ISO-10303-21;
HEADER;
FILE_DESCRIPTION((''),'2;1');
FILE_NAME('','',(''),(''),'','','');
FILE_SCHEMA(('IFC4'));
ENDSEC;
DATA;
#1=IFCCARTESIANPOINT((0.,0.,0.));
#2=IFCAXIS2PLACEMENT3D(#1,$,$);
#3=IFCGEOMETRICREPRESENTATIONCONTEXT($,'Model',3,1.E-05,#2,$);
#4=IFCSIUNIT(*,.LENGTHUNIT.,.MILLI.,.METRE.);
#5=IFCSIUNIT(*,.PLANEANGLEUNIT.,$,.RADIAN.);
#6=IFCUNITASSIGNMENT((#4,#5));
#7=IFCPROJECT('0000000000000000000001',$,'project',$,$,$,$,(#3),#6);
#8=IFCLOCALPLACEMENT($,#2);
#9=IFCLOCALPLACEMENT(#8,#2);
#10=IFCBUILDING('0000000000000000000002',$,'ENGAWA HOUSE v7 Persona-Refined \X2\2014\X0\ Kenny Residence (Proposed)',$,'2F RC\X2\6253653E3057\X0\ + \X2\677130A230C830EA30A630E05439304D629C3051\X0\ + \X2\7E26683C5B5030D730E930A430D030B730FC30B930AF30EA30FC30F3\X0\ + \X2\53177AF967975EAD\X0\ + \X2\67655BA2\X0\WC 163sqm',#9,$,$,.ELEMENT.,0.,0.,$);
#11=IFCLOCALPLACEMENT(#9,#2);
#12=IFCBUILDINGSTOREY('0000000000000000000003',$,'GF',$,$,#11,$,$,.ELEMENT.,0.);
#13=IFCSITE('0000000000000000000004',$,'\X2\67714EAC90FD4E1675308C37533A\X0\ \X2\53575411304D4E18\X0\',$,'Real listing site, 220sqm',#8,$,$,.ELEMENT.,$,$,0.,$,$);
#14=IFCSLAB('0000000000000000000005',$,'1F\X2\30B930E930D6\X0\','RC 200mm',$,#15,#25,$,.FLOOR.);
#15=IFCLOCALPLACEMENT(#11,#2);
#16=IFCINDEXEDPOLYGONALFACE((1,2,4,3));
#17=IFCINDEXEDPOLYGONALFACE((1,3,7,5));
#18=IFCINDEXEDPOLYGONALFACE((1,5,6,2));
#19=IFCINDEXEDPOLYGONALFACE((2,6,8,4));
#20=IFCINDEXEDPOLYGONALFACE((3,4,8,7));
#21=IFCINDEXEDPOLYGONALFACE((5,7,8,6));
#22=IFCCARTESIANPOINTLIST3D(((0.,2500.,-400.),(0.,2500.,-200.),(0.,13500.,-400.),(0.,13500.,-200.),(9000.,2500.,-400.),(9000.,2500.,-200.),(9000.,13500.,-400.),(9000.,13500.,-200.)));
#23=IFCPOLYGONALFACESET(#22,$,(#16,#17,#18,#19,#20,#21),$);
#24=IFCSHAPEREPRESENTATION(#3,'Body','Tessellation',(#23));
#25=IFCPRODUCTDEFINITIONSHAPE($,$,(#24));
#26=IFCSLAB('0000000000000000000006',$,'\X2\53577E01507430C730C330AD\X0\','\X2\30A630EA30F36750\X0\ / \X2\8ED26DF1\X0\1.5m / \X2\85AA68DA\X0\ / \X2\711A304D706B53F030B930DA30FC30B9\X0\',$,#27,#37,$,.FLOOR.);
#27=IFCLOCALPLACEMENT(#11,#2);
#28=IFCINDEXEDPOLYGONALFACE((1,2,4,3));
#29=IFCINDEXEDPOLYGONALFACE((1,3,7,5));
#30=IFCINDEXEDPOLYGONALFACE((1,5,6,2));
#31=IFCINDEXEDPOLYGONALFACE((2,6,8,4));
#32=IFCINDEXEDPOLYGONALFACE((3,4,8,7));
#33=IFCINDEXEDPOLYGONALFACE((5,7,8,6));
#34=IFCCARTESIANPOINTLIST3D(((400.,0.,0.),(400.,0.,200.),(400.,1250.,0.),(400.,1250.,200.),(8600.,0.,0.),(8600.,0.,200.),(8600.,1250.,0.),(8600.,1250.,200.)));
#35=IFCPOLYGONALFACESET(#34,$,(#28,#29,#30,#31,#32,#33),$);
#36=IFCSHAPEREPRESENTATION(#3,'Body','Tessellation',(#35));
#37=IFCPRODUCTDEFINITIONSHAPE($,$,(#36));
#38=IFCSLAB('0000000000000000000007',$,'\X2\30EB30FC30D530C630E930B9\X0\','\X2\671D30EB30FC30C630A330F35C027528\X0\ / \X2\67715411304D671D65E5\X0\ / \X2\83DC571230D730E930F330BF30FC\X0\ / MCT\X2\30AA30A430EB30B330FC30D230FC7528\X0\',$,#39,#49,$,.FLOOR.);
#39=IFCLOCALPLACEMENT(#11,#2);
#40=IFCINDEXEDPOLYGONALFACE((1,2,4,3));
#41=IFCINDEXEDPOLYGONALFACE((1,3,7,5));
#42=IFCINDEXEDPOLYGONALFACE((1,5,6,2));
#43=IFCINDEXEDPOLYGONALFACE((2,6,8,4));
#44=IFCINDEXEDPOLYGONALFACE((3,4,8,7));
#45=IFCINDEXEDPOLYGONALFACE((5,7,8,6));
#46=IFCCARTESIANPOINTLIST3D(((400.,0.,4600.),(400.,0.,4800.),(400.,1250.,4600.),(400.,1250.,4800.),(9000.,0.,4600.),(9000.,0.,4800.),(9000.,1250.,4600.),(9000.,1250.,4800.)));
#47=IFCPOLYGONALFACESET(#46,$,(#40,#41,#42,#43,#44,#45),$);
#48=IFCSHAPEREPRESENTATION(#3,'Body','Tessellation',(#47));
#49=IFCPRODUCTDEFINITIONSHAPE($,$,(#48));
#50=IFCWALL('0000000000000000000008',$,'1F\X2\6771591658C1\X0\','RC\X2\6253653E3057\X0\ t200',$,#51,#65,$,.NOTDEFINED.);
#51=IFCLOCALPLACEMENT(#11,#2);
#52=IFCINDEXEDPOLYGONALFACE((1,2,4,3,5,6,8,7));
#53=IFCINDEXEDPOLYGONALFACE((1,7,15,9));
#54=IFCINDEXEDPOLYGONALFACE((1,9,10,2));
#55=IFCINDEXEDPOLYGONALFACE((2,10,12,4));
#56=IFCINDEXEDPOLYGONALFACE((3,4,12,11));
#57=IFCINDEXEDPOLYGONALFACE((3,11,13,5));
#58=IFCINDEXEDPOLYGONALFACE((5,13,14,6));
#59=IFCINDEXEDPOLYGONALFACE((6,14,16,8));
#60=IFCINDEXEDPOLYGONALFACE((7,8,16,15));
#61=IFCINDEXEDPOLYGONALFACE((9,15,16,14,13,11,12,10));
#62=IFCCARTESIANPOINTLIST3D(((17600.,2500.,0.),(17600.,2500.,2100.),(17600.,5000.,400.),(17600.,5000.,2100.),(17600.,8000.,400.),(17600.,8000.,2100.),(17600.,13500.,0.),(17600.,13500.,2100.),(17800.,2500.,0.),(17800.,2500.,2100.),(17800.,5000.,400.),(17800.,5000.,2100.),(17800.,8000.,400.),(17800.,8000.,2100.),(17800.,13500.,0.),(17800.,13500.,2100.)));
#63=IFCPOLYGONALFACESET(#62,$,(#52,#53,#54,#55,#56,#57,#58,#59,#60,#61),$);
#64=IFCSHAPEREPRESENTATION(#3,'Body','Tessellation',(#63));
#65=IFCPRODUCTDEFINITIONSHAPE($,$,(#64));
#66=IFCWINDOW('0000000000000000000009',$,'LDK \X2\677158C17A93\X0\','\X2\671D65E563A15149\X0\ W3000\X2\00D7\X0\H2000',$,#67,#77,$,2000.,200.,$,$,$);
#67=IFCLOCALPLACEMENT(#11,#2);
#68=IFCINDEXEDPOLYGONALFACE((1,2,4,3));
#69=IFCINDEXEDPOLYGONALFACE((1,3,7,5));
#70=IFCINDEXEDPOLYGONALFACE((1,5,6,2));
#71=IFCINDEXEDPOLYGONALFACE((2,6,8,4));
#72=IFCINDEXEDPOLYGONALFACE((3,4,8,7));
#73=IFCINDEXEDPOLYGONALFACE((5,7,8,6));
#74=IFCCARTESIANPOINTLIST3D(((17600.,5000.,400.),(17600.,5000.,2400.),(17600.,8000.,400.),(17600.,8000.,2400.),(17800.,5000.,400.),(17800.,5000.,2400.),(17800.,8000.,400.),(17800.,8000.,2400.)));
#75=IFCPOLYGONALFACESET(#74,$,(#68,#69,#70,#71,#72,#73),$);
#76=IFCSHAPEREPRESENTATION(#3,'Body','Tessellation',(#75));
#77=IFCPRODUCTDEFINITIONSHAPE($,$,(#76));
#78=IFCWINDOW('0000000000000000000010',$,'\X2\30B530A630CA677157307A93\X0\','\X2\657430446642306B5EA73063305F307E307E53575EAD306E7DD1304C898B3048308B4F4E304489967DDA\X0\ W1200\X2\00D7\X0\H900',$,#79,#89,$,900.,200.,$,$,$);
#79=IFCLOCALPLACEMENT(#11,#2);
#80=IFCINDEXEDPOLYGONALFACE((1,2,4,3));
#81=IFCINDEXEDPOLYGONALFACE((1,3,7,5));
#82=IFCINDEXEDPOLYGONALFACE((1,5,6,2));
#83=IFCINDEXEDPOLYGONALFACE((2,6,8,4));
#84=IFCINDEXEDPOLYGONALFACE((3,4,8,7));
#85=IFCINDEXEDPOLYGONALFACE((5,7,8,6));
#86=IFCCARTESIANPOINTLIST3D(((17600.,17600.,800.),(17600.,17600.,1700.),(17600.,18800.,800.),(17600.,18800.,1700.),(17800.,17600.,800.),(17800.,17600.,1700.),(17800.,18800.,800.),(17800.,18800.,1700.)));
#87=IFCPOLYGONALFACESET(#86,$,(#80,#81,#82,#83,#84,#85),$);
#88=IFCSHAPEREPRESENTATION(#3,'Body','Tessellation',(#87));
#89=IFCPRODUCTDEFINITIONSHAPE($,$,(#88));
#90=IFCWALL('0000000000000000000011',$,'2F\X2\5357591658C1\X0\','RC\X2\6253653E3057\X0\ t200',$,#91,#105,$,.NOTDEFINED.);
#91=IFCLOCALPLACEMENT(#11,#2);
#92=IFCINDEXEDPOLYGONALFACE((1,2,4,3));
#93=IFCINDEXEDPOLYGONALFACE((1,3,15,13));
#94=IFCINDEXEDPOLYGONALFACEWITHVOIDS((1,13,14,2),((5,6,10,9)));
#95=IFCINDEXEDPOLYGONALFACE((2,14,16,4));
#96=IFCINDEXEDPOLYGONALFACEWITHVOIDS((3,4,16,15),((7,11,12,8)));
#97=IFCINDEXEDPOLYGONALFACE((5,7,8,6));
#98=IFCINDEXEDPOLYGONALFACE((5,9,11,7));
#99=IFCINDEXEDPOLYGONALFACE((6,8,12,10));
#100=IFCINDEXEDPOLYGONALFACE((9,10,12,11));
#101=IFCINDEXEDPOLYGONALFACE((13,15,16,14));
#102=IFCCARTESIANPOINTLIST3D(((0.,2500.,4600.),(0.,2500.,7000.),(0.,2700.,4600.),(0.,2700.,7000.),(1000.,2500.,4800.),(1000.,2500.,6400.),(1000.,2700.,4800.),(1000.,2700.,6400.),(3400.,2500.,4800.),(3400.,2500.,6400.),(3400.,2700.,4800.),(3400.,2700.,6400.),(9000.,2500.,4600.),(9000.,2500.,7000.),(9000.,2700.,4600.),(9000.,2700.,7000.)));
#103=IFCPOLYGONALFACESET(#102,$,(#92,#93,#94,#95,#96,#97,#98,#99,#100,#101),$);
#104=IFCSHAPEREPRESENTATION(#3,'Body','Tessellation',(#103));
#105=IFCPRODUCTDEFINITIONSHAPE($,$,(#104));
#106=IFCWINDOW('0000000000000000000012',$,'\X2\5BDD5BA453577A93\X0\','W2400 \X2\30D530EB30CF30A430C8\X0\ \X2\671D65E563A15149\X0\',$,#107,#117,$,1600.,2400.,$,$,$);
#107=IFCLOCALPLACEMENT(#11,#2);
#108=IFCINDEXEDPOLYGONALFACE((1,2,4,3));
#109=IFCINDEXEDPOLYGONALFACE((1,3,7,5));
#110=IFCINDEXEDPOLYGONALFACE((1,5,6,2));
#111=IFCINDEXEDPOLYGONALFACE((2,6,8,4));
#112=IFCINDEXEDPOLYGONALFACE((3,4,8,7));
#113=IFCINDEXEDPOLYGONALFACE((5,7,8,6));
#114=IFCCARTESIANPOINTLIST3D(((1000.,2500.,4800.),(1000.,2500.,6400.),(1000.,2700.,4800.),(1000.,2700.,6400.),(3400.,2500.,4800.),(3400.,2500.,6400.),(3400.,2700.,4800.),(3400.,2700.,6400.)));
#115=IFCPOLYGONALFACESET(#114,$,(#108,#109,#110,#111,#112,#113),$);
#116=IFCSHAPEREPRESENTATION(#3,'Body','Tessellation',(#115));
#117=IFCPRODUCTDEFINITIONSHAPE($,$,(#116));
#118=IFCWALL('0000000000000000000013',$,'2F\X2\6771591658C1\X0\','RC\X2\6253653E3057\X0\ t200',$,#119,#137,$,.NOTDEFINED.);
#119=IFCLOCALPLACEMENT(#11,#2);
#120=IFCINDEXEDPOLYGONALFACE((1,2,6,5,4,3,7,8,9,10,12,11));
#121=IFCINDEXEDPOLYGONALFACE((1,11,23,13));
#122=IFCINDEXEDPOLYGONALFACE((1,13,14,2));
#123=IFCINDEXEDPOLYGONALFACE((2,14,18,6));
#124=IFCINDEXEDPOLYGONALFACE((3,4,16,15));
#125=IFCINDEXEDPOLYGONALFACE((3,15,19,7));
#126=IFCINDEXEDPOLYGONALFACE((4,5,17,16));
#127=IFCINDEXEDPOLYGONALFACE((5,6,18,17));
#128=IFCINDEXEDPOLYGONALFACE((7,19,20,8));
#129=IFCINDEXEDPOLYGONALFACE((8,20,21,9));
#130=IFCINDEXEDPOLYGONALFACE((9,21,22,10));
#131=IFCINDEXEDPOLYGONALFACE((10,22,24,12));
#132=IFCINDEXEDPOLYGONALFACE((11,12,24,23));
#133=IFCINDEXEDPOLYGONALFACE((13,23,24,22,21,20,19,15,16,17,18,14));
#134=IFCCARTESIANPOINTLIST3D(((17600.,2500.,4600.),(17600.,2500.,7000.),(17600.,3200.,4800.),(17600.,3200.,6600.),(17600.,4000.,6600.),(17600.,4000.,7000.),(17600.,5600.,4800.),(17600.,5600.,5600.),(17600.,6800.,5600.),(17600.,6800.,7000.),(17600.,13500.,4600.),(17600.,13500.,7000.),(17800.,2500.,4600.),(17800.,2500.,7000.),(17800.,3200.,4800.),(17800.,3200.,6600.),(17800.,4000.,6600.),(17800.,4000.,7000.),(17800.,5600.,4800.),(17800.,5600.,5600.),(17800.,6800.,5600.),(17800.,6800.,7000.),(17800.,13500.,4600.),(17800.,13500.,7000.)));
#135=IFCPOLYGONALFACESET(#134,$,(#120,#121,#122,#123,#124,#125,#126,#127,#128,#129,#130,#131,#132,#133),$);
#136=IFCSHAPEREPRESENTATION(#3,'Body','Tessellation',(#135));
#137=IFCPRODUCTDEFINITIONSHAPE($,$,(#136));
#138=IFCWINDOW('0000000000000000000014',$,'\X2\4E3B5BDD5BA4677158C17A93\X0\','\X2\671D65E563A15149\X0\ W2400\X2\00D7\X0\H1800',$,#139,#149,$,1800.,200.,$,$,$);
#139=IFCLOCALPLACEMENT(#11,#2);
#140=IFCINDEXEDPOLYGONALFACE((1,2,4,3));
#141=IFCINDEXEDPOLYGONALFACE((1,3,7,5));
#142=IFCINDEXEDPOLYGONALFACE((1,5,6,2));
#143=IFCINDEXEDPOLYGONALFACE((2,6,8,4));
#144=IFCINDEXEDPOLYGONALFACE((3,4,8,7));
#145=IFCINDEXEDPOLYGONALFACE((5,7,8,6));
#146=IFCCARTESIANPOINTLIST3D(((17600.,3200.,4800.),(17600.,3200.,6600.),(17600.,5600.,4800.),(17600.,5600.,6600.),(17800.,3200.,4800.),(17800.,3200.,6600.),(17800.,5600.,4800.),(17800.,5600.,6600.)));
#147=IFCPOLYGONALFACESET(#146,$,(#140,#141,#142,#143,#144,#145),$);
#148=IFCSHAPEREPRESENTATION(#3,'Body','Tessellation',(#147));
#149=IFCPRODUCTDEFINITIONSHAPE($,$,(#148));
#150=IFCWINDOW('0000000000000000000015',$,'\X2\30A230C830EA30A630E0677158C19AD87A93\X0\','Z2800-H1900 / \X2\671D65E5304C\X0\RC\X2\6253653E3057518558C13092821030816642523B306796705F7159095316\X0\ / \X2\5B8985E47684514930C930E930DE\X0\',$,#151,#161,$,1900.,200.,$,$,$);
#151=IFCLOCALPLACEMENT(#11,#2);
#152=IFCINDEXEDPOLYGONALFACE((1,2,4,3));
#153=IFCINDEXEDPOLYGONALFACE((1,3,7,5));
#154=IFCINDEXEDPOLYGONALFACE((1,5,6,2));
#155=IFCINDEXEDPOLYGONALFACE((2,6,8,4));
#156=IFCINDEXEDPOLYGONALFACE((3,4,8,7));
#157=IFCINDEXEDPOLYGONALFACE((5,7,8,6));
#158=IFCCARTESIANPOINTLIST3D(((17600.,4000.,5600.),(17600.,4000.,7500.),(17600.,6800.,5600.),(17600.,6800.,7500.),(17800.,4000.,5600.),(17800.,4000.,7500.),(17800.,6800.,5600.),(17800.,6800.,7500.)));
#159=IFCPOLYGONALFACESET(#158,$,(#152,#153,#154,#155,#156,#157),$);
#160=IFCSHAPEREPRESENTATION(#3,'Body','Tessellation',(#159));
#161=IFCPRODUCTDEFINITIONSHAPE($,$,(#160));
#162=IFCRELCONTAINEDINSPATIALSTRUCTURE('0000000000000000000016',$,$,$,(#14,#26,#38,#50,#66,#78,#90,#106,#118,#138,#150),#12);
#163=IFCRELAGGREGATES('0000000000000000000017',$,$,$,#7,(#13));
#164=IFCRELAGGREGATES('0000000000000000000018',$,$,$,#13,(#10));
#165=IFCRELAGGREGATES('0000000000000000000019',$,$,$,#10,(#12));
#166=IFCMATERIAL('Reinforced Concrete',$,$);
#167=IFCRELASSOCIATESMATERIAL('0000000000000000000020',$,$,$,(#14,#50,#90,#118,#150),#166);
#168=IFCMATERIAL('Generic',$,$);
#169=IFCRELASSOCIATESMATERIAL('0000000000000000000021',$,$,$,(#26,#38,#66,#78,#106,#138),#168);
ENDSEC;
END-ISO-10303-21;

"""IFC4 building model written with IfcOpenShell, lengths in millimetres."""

from ifc_helpers import new_model, si_unit, frame, frame_2d, origin, place, context, project, spatial, rectangle, extrude, material, element, fill, save


model = new_model("IFC4")

# Units and contexts
model_context = context("Model", 3, precision=1e-05, world=origin())
ifc_project = project(units=[si_unit("LENGTHUNIT", "METRE", prefix="MILLI"), si_unit("PLANEANGLEUNIT", "RADIAN")], contexts=[model_context])

# Site, building, storey
site_placement = place(None, origin())
site = spatial("IfcSite", under=ifc_project, at=site_placement, Name="東京都世田谷区 南向き丘", ObjectType="Real listing site, 220sqm", CompositionType="ELEMENT", RefElevation=0.0)
building_placement = place(site_placement, origin())
building = spatial("IfcBuilding", under=site, at=building_placement, Name="ENGAWA HOUSE v7 Persona-Refined — Kenny Residence (Proposed)", ObjectType="2F RC打放し + 東アトリウム吹き抜け + 縦格子プライバシースクリーン + 北竹林庭 + 来客WC 163sqm", CompositionType="ELEMENT", ElevationOfRefHeight=0.0, ElevationOfTerrain=0.0)
storey_placement = place(building_placement, origin())
storey = spatial("IfcBuildingStorey", under=building, at=storey_placement, Name="GF", CompositionType="ELEMENT", Elevation=0.0)

# Shared definitions
ifc_material_1 = material(Name="Generic")

# Slabs
ifc_material_2 = material(Name="Reinforced Concrete")
slab_1_placement = place(storey_placement, frame((0.0, 1250.0, -200.0)))
element("IfcSlab", 1, at=slab_1_placement, inside=storey, material=ifc_material_2, Name="1Fスラブ", Description="RC 200mm", PredefinedType="FLOOR", context=model_context, shape_type="SweptSolid", body=[
    extrude(rectangle(XDim=9000.0, YDim=11000.0, at=frame_2d((4500.0, 5500.0))), frame((0.0, 1250.0, -200.0)), (0.0, 0.0, 1.0), 200.0),
])
slab_2_placement = place(storey_placement, frame((200.0, 0.0, 0.0)))
element("IfcSlab", 2, at=slab_2_placement, inside=storey, material=ifc_material_1, Name="南縁側デッキ", Description="ウリン材 / 軒深1.5m / 薪棚 / 焚き火台スペース", PredefinedType="FLOOR", context=model_context, shape_type="SweptSolid", body=[
    extrude(rectangle(XDim=8200.0, YDim=1250.0, at=frame_2d((4100.0, 625.0))), frame((200.0, 0.0, 0.0)), (0.0, 0.0, 1.0), 200.0),
])
slab_3_placement = place(storey_placement, frame((200.0, 0.0, 2300.0)))
element("IfcSlab", 3, at=slab_3_placement, inside=storey, material=ifc_material_1, Name="ルーフテラス", Description="朝ルーティン専用 / 東向き朝日 / 菜園プランター / MCTオイルコーヒー用", PredefinedType="FLOOR", context=model_context, shape_type="SweptSolid", body=[
    extrude(rectangle(XDim=8600.0, YDim=1250.0, at=frame_2d((4300.0, 625.0))), frame((200.0, 0.0, 2300.0)), (0.0, 0.0, 1.0), 200.0),
])

# Wall, openings, windows
wall_1_placement = place(storey_placement, frame((8800.0, 1250.0, 0.0)))
wall_1 = element("IfcWall", 4, at=wall_1_placement, inside=storey, material=ifc_material_2, Name="1F東外壁", Description="RC打放し t200", PredefinedType="NOTDEFINED", context=model_context, shape_type="SweptSolid", body=[
    extrude(rectangle(XDim=200.0, YDim=11000.0, at=frame_2d((100.0, 5500.0))), frame((8800.0, 1250.0, 0.0)), (0.0, 0.0, 1.0), 2100.0),
])
opening_1_placement = place(storey_placement, frame((8800.0, 2500.0, 200.0)))
opening_1 = element("IfcOpeningElement", 5, at=opening_1_placement, cuts=wall_1, PredefinedType="NOTDEFINED", context=model_context, shape_type="SweptSolid", body=[
    extrude(rectangle(XDim=200.0, YDim=3000.0, at=frame_2d((100.0, 1500.0))), frame((8800.0, 2500.0, 200.0)), (0.0, 0.0, 1.0), 2000.0),
])
opening_2_placement = place(storey_placement, frame((8800.0, 8800.0, 400.0)))
opening_2 = element("IfcOpeningElement", 6, at=opening_2_placement, cuts=wall_1, PredefinedType="NOTDEFINED", context=model_context, shape_type="SweptSolid", body=[
    extrude(rectangle(XDim=200.0, YDim=1200.0, at=frame_2d((100.0, 600.0))), frame((8800.0, 8800.0, 400.0)), (0.0, 0.0, 1.0), 900.0),
])
window_1_placement = place(storey_placement, frame((8800.0, 2500.0, 200.0)))
window_1 = element("IfcWindow", 7, at=window_1_placement, inside=storey, material=ifc_material_1, Name="LDK 東壁窓", Description="朝日採光 W3000×H2000", OverallHeight=2000.0, OverallWidth=200.0, context=model_context, shape_type="SweptSolid", body=[
    extrude(rectangle(XDim=200.0, YDim=3000.0, at=frame_2d((100.0, 1500.0))), frame((8800.0, 2500.0, 200.0)), (0.0, 0.0, 1.0), 2000.0),
])
fill(opening_1, window_1)
window_2_placement = place(storey_placement, frame((8800.0, 8800.0, 400.0)))
window_2 = element("IfcWindow", 8, at=window_2_placement, inside=storey, material=ifc_material_1, Name="サウナ東地窓", Description="整い時に座ったまま南庭の緑が見える低い視線 W1200×H900", OverallHeight=900.0, OverallWidth=200.0, context=model_context, shape_type="SweptSolid", body=[
    extrude(rectangle(XDim=200.0, YDim=1200.0, at=frame_2d((100.0, 600.0))), frame((8800.0, 8800.0, 400.0)), (0.0, 0.0, 1.0), 900.0),
])
fill(opening_2, window_2)

# Wall, opening, window
wall_2_placement = place(storey_placement, frame((0.0, 1250.0, 2300.0)))
wall_2 = element("IfcWall", 9, at=wall_2_placement, inside=storey, material=ifc_material_2, Name="2F南外壁", Description="RC打放し t200", PredefinedType="NOTDEFINED", context=model_context, shape_type="SweptSolid", body=[
    extrude(rectangle(XDim=9000.0, YDim=200.0, at=frame_2d((4500.0, 100.0))), frame((0.0, 1250.0, 2300.0)), (0.0, 0.0, 1.0), 2400.0),
])
opening_3_placement = place(storey_placement, frame((500.0, 1250.0, 2400.0)))
opening_3 = element("IfcOpeningElement", 10, at=opening_3_placement, cuts=wall_2, PredefinedType="NOTDEFINED", context=model_context, shape_type="SweptSolid", body=[
    extrude(rectangle(XDim=2400.0, YDim=200.0, at=frame_2d((1200.0, 100.0))), frame((500.0, 1250.0, 2400.0)), (0.0, 0.0, 1.0), 1600.0),
])
window_3_placement = place(storey_placement, frame((500.0, 1250.0, 2400.0)))
window_3 = element("IfcWindow", 11, at=window_3_placement, inside=storey, material=ifc_material_1, Name="寝室南窓", Description="W2400 フルハイト 朝日採光", OverallHeight=1600.0, OverallWidth=2400.0, context=model_context, shape_type="SweptSolid", body=[
    extrude(rectangle(XDim=2400.0, YDim=200.0, at=frame_2d((1200.0, 100.0))), frame((500.0, 1250.0, 2400.0)), (0.0, 0.0, 1.0), 1600.0),
])
fill(opening_3, window_3)

# Wall, openings, windows
wall_3_placement = place(storey_placement, frame((8800.0, 1250.0, 2300.0)))
wall_3 = element("IfcWall", 12, at=wall_3_placement, inside=storey, material=ifc_material_2, Name="2F東外壁", Description="RC打放し t200", PredefinedType="NOTDEFINED", context=model_context, shape_type="SweptSolid", body=[
    extrude(rectangle(XDim=200.0, YDim=11000.0, at=frame_2d((100.0, 5500.0))), frame((8800.0, 1250.0, 2300.0)), (0.0, 0.0, 1.0), 2400.0),
])
opening_4_placement = place(storey_placement, frame((8800.0, 1600.0, 2400.0)))
opening_4 = element("IfcOpeningElement", 13, at=opening_4_placement, cuts=wall_3, PredefinedType="NOTDEFINED", context=model_context, shape_type="SweptSolid", body=[
    extrude(rectangle(XDim=200.0, YDim=2400.0, at=frame_2d((100.0, 1200.0))), frame((8800.0, 1600.0, 2400.0)), (0.0, 0.0, 1.0), 1800.0),
])
opening_5_placement = place(storey_placement, frame((8800.0, 2000.0, 2800.0)))
opening_5 = element("IfcOpeningElement", 14, at=opening_5_placement, cuts=wall_3, PredefinedType="NOTDEFINED", context=model_context, shape_type="SweptSolid", body=[
    extrude(rectangle(XDim=200.0, YDim=2800.0, at=frame_2d((100.0, 1400.0))), frame((8800.0, 2000.0, 2800.0)), (0.0, 0.0, 1.0), 1900.0),
])
window_4_placement = place(storey_placement, frame((8800.0, 1600.0, 2400.0)))
window_4 = element("IfcWindow", 15, at=window_4_placement, inside=storey, material=ifc_material_1, Name="主寝室東壁窓", Description="朝日採光 W2400×H1800", OverallHeight=1800.0, OverallWidth=200.0, context=model_context, shape_type="SweptSolid", body=[
    extrude(rectangle(XDim=200.0, YDim=2400.0, at=frame_2d((100.0, 1200.0))), frame((8800.0, 1600.0, 2400.0)), (0.0, 0.0, 1.0), 1800.0),
])
fill(opening_4, window_4)
window_5_placement = place(storey_placement, frame((8800.0, 2000.0, 2800.0)))
window_5 = element("IfcWindow", 16, at=window_5_placement, inside=storey, material=ifc_material_2, Name="アトリウム東壁高窓", Description="Z2800-H1900 / 朝日がRC打放し内壁を舐め時刻で陰影変化 / 安藤的光ドラマ", OverallHeight=1900.0, OverallWidth=200.0, context=model_context, shape_type="SweptSolid", body=[
    extrude(rectangle(XDim=200.0, YDim=2800.0, at=frame_2d((100.0, 1400.0))), frame((8800.0, 2000.0, 2800.0)), (0.0, 0.0, 1.0), 1900.0),
])
fill(opening_5, window_5)

save(model, "model.ifc")
